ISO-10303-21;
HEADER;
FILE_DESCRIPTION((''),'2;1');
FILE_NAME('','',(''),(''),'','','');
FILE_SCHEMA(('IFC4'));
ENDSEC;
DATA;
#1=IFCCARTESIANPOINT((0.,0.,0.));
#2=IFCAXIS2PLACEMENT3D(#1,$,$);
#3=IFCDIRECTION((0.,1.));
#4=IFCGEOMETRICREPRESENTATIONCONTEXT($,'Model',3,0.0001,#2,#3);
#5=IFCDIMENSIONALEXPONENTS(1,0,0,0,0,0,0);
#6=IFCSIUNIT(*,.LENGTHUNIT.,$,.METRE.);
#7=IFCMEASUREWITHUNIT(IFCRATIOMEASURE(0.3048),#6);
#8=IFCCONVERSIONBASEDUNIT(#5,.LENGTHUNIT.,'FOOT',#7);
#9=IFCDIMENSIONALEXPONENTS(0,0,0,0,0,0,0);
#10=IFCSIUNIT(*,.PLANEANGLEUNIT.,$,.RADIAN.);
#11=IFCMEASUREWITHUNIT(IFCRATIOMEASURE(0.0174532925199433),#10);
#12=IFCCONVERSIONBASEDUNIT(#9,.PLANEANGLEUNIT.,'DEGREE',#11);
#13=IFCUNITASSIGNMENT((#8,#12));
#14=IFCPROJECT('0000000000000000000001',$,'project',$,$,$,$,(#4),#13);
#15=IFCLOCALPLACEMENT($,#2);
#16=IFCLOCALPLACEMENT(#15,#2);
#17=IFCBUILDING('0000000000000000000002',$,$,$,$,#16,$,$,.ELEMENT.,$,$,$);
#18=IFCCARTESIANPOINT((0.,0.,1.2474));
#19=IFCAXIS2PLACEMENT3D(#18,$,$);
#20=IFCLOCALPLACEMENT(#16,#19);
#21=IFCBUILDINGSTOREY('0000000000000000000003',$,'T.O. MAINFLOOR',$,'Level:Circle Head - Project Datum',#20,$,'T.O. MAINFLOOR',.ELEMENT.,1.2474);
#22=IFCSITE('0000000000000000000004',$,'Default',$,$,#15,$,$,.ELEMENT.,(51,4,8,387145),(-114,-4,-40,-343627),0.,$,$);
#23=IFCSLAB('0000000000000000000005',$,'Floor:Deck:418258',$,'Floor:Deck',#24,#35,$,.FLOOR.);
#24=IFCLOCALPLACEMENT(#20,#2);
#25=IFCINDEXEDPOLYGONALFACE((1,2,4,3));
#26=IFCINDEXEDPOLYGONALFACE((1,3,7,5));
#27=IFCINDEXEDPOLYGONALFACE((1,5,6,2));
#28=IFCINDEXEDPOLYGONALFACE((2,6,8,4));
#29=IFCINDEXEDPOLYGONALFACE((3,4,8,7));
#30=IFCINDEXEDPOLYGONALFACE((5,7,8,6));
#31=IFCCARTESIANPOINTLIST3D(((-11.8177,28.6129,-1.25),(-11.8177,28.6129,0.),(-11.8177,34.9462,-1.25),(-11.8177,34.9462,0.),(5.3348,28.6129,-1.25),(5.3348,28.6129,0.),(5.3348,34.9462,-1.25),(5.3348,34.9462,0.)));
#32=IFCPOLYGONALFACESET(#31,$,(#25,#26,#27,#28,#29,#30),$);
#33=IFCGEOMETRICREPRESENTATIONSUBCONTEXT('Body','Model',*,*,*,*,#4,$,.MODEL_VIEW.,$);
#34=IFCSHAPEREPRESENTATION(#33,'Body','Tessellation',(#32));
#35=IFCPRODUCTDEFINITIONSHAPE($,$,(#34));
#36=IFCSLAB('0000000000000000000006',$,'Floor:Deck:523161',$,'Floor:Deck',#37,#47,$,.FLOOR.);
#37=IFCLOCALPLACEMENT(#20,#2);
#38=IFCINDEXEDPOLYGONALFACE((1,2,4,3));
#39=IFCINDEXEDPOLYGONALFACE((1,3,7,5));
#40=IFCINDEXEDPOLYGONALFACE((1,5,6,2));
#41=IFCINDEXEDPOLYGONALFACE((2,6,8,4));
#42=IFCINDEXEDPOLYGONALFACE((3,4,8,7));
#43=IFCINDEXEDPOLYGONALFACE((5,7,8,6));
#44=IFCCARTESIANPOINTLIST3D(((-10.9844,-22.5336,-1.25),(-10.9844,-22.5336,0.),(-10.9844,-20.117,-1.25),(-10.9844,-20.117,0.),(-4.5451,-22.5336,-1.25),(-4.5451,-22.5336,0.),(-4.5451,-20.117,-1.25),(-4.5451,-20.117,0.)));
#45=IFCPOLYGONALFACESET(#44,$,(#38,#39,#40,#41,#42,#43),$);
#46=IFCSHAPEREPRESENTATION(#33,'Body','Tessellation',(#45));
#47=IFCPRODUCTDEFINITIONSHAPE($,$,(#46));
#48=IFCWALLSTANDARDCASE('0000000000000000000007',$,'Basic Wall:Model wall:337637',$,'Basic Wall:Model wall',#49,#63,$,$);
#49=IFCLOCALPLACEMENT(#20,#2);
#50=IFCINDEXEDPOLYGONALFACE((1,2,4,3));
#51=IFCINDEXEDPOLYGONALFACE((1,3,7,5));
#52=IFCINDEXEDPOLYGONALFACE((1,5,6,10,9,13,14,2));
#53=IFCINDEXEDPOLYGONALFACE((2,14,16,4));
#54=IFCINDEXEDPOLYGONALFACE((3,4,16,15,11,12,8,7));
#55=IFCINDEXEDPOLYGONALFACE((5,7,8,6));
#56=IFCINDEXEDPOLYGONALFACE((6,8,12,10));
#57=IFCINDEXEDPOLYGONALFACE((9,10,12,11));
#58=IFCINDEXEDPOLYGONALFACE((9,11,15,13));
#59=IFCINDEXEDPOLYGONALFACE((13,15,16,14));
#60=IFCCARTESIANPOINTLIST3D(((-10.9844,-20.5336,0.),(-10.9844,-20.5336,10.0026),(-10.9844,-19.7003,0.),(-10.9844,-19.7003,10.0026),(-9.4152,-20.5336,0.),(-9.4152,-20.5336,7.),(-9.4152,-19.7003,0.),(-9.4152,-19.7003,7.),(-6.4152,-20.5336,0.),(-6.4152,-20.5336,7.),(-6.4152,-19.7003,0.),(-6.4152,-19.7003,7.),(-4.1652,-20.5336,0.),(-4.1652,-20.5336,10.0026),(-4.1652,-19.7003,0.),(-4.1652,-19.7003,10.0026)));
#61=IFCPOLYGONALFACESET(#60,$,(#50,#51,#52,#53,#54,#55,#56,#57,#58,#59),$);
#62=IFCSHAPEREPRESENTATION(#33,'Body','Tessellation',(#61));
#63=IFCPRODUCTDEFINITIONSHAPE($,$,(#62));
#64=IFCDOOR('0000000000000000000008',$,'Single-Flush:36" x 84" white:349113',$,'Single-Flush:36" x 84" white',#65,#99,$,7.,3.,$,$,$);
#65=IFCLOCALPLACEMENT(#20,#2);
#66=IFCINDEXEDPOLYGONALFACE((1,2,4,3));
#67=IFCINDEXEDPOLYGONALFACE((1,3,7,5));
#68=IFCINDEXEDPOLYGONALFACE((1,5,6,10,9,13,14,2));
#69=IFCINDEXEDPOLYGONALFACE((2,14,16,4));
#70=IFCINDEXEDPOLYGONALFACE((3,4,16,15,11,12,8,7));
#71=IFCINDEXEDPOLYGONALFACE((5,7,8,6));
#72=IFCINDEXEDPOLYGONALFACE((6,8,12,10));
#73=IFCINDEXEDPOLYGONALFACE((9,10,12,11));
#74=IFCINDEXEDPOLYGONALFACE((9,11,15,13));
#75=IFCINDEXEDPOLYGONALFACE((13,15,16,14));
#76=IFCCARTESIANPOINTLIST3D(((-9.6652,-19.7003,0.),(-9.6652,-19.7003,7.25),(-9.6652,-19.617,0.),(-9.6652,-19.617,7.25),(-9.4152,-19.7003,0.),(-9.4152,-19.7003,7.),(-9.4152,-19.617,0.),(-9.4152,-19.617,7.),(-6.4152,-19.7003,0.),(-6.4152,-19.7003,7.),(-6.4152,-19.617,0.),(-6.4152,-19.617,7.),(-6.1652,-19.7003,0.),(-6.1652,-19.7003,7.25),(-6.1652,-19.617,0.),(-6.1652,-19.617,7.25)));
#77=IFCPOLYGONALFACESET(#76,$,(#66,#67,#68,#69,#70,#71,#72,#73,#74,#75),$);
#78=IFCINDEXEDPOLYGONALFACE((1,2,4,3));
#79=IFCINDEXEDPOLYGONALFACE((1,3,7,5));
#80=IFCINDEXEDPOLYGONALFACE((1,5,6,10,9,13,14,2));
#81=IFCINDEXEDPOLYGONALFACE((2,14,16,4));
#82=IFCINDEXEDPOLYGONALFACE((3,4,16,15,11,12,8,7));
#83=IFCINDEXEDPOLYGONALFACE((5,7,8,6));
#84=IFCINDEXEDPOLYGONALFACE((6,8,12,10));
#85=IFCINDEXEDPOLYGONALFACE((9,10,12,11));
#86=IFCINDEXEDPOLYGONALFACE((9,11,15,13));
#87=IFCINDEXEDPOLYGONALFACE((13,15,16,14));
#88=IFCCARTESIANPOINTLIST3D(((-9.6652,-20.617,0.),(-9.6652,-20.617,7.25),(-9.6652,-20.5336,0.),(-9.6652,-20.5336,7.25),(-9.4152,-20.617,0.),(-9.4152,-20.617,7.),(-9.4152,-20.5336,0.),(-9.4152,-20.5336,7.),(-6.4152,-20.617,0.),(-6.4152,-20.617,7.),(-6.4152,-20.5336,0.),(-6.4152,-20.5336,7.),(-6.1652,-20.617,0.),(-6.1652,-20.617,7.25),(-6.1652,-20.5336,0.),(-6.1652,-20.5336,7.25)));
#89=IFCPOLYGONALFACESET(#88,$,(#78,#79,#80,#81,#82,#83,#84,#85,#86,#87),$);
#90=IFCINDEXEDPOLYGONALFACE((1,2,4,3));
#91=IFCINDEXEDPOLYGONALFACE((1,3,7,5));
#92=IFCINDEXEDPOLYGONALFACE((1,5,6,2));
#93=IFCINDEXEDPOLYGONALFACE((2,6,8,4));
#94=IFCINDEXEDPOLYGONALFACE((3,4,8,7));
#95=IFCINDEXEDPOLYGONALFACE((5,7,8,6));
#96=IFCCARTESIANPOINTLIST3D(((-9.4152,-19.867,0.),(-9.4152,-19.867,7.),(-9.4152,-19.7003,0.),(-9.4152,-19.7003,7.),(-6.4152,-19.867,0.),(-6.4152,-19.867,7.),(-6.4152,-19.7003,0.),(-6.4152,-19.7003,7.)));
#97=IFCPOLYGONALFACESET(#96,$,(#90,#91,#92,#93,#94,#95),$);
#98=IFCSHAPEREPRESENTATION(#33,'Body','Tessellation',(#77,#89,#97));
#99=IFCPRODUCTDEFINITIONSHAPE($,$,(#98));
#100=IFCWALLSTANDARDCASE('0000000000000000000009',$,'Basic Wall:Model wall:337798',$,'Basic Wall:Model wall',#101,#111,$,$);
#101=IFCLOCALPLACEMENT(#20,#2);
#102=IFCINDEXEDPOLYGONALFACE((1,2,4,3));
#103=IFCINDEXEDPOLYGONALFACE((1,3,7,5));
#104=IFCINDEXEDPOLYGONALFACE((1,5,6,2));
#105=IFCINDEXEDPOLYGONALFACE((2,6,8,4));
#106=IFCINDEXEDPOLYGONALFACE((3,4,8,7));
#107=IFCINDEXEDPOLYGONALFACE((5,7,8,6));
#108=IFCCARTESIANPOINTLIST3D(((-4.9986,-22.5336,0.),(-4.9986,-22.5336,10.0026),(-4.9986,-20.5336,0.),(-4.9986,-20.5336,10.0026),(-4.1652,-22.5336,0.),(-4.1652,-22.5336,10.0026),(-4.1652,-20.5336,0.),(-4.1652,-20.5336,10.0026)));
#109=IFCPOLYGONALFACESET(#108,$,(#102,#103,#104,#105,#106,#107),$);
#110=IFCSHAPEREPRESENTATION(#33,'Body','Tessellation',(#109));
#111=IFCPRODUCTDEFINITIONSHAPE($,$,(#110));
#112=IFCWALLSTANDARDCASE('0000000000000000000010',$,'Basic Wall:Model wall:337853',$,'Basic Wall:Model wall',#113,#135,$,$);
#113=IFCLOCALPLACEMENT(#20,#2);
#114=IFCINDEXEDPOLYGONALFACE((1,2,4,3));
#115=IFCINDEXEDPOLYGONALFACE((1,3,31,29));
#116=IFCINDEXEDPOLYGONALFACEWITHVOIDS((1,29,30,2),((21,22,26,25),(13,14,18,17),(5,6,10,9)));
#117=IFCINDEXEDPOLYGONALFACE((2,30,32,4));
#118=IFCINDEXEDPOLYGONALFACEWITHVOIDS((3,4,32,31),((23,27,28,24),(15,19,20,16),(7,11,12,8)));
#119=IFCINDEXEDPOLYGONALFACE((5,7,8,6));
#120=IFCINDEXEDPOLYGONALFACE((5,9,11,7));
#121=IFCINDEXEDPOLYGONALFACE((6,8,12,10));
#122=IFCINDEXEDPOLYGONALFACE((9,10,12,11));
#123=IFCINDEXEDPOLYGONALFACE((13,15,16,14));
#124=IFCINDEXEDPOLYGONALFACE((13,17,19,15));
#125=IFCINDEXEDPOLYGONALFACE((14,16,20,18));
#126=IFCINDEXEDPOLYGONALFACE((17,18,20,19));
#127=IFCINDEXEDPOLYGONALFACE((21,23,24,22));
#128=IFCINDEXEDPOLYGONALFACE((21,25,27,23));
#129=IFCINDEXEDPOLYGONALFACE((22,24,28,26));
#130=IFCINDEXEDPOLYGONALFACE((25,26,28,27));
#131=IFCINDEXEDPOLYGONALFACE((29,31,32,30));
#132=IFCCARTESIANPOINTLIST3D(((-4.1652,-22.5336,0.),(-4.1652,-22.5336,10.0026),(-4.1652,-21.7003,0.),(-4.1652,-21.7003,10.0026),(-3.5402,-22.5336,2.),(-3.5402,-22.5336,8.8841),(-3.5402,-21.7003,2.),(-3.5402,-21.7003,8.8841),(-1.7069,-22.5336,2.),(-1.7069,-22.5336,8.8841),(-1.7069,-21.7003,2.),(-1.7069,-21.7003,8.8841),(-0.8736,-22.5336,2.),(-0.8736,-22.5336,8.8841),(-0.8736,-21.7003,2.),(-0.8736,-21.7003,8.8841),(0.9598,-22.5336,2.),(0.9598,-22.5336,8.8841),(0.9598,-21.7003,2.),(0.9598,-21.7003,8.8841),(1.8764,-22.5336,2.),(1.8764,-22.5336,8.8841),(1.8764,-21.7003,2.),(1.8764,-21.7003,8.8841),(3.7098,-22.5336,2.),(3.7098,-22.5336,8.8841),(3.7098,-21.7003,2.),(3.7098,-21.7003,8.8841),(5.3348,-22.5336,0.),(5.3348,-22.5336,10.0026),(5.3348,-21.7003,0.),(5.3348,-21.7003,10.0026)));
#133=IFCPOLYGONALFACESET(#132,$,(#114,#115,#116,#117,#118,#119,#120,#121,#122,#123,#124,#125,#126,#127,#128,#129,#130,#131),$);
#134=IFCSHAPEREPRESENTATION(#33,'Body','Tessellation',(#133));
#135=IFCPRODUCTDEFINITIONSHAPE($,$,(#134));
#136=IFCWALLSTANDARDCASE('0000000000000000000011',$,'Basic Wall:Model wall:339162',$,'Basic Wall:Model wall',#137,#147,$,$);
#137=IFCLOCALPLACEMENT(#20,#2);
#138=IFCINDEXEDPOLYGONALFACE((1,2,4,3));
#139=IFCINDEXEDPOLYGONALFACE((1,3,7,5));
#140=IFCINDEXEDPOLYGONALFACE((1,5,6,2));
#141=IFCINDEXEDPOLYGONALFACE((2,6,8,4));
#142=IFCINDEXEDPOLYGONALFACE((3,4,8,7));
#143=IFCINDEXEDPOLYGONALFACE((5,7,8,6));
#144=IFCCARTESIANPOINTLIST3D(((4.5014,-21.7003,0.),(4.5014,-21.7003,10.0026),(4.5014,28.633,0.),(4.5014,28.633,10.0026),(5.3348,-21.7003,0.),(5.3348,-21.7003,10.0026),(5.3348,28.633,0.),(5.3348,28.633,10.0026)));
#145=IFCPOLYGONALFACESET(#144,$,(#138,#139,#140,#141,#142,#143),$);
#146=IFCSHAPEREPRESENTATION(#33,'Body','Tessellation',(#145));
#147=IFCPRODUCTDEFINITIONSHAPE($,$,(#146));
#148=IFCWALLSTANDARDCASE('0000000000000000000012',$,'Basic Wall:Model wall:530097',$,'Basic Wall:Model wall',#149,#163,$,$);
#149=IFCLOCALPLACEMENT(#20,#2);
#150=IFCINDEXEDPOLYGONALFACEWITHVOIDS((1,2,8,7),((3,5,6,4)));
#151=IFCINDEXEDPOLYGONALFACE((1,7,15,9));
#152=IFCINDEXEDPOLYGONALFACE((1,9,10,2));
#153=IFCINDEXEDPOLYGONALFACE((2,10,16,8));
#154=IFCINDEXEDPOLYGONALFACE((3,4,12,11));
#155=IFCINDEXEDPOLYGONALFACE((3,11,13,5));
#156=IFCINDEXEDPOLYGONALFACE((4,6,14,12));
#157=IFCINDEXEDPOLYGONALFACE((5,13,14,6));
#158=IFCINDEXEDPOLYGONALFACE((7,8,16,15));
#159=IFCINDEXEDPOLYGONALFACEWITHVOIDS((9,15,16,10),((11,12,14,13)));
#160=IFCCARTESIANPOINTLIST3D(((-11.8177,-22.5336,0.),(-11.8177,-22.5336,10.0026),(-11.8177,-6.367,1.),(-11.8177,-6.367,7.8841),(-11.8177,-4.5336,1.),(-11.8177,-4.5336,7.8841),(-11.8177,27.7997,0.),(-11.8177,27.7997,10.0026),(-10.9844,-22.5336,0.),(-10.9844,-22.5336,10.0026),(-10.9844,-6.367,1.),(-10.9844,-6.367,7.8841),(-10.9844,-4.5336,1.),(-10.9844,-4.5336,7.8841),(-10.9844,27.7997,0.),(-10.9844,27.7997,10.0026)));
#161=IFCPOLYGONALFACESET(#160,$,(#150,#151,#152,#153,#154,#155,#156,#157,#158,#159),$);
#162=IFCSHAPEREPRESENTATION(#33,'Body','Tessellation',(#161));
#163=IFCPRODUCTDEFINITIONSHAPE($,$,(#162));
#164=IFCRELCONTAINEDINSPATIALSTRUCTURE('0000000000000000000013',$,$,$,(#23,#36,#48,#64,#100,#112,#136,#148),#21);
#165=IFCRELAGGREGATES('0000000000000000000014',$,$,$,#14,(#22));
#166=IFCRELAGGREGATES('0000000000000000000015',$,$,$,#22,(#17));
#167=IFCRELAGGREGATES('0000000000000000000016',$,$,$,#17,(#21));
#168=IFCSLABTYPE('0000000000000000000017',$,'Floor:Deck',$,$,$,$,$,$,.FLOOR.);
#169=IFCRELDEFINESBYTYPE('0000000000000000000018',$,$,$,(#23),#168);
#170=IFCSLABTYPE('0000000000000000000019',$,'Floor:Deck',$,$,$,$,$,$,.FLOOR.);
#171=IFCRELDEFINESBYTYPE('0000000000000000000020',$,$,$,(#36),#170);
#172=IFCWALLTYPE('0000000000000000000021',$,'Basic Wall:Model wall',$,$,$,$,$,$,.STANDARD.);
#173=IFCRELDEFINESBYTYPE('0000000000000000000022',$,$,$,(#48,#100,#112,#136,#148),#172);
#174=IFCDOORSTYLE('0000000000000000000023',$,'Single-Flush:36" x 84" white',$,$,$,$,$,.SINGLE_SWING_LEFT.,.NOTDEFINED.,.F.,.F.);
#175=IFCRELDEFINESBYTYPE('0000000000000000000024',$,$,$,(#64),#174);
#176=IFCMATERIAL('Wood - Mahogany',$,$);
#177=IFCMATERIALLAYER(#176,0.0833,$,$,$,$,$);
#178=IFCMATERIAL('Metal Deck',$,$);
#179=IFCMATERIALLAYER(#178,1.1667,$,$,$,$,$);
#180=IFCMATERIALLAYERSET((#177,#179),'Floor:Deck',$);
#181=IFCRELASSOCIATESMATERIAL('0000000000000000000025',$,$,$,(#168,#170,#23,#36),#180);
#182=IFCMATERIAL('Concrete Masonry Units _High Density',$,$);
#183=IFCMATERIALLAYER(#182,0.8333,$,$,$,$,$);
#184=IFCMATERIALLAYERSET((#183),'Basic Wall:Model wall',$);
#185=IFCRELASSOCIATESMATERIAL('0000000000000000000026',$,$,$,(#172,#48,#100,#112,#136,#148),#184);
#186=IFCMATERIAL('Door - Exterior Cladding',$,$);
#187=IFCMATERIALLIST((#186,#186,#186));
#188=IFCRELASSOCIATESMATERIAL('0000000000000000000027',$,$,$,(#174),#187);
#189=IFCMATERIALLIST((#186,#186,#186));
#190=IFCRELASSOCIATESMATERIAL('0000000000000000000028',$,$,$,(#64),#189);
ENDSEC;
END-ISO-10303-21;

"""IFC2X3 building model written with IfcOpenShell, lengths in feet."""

from ifc_helpers import new_model, entity, si_unit, converted_unit, direction, frame, frame_2d, origin, origin_2d_with_axis, place, context, subcontext, project, spatial, polyline, rectangle, outline, extrude, source, transform, mapped, material, material_list, layer, layer_set, layer_usage, type_object, type_shapes, element, fill, save


model = new_model("IFC2X3")

# Units and contexts
model_context = context("Model", 3, precision=0.0001, world=origin(), true_north=direction((0.0, 1.0)))
body_context = subcontext(model_context, "Body", "Model", "MODEL_VIEW")
ifc_project = project(units=[converted_unit("LENGTHUNIT", "FOOT", entity("IfcRatioMeasure", 0.3048), si_unit("LENGTHUNIT", "METRE"), dimensions=[1, 0, 0, 0, 0, 0, 0]), converted_unit("PLANEANGLEUNIT", "DEGREE", entity("IfcRatioMeasure", 0.0174532925199433), si_unit("PLANEANGLEUNIT", "RADIAN"), dimensions=[0, 0, 0, 0, 0, 0, 0])], contexts=[model_context])

# Site, building, storey
site_placement = place(None, origin())
site = spatial("IfcSite", under=ifc_project, at=site_placement, Name="Default", CompositionType="ELEMENT", RefLatitude=(51, 4, 8, 387145), RefLongitude=(-114, -4, -40, -343627), RefElevation=0.0)
building_placement = place(site_placement, origin())
building = spatial("IfcBuilding", under=site, at=building_placement, CompositionType="ELEMENT")
storey_placement = place(building_placement, frame((0.0, 0.0, 1.2474)))
storey = spatial("IfcBuildingStorey", under=building, at=storey_placement, Name="T.O. MAINFLOOR", ObjectType="Level:Circle Head - Project Datum", LongName="T.O. MAINFLOOR", CompositionType="ELEMENT", Elevation=1.2474)

# Slabs
ifc_material_1 = material(Name="Wood - Mahogany")
ifc_layer_1 = layer(ifc_material_1, 0.0833)
ifc_material_2 = material(Name="Metal Deck")
ifc_layer_2 = layer(ifc_material_2, 1.1667)
ifc_layer_set_1 = layer_set([ifc_layer_1, ifc_layer_2], Name="Floor:Deck")
ifc_layer_usage_1 = layer_usage(ifc_layer_set_1, "AXIS3", "POSITIVE", 0.0)
slab_type_1 = type_object("IfcSlabType", Name="Floor:Deck", PredefinedType="FLOOR", material=ifc_layer_set_1)
slab_1_placement = place(storey_placement, origin())
element("IfcSlab", 1, at=slab_1_placement, inside=storey, type_object=slab_type_1, material=ifc_layer_usage_1, Name="Floor:Deck:418258", ObjectType="Floor:Deck", PredefinedType="FLOOR", context=body_context, shape_type="SweptSolid", body=[
    extrude(rectangle(XDim=6.3333, YDim=17.1525, at=frame_2d((0.0, 0.0), x_axis=(1.0, 0.0))), frame((-3.2415, 31.7795, 0.0), z_axis=(0.0, 0.0, -1.0), x_axis=(0.0, 1.0, 0.0)), (0.0, 0.0, 1.0), 1.25),
])
ifc_layer_usage_2 = layer_usage(ifc_layer_set_1, "AXIS3", "POSITIVE", 0.0)
slab_type_2 = type_object("IfcSlabType", Name="Floor:Deck", PredefinedType="FLOOR", material=ifc_layer_set_1)
slab_2_placement = place(storey_placement, origin())
element("IfcSlab", 2, at=slab_2_placement, inside=storey, type_object=slab_type_2, material=ifc_layer_usage_2, Name="Floor:Deck:523161", ObjectType="Floor:Deck", PredefinedType="FLOOR", context=body_context, shape_type="SweptSolid", body=[
    extrude(rectangle(XDim=2.4167, YDim=6.4392, at=origin_2d_with_axis()), frame((-7.7648, -21.3253, 0.0), z_axis=(0.0, 0.0, -1.0), x_axis=(0.0, 1.0, 0.0)), (0.0, 0.0, 1.0), 1.25),
])

# Wall, opening, door
ifc_material_3 = material(Name="Concrete Masonry Units _High Density")
ifc_layer_3 = layer(ifc_material_3, 0.8333)
ifc_layer_set_2 = layer_set([ifc_layer_3], Name="Basic Wall:Model wall")
ifc_layer_usage_3 = layer_usage(ifc_layer_set_2, "AXIS2", "NEGATIVE", 0.4167)
wall_type_1 = type_object("IfcWallType", Name="Basic Wall:Model wall", PredefinedType="STANDARD", material=ifc_layer_set_2)
wall_1_placement = place(storey_placement, frame((-10.9844, -20.117, 0.0)))
wall_1 = element("IfcWallStandardCase", 3, at=wall_1_placement, inside=storey, type_object=wall_type_1, material=ifc_layer_usage_3, Name="Basic Wall:Model wall:337637", ObjectType="Basic Wall:Model wall", context=body_context, shape_type="SweptSolid", body=[
    extrude(rectangle(XDim=6.8192, YDim=0.8333, at=frame_2d((3.4096, 0.0), x_axis=(-1.0, 0.0))), origin(), (0.0, 0.0, 1.0), 10.0026),
])
opening_1_placement = place(wall_1_placement, frame((1.5692, -0.4167, 0.0)))
opening_1 = element("IfcOpeningElement", 4, at=opening_1_placement, cuts=wall_1, ObjectType="Opening", context=body_context, shape_type="SweptSolid", body=[
    extrude(rectangle(XDim=3.0, YDim=7.0, at=frame_2d((3.5, 1.5), x_axis=(0.0, -1.0))), frame((0.0, 0.0, 0.0), z_axis=(0.0, 1.0, 0.0), x_axis=(0.0, 0.0, 1.0)), (0.0, 0.0, 1.0), 0.8333),
])
ifc_material_4 = material(Name="Door - Exterior Cladding")
ifc_material_list_1 = material_list([ifc_material_4, ifc_material_4, ifc_material_4])
ifc_material_list_2 = material_list([ifc_material_4, ifc_material_4, ifc_material_4])
door_style_1 = type_object("IfcDoorStyle", Name="Single-Flush:36\" x 84\" white", ConstructionType="NOTDEFINED", OperationType="SINGLE_SWING_LEFT", ParameterTakesPrecedence=False, Sizeable=False, material=ifc_material_list_2)
shared_shape_1 = source(origin(), body_context, "Body", "SweptSolid", [
    extrude(outline(polyline([(-1.75, -3.6875), (1.75, -3.6875), (1.75, 3.5625), (1.5, 3.5625), (1.5, -3.4375), (-1.5, -3.4375), (-1.5, 3.5625), (-1.75, 3.5625), (-1.75, -3.6875)])), frame((1.5, 0.9167, 3.5625), z_axis=(0.0, -1.0, 0.0), x_axis=(-1.0, 0.0, 0.0)), (0.0, 0.0, 1.0), 0.0833),
    extrude(outline(polyline([(-3.6875, -1.75), (3.5625, -1.75), (3.5625, -1.5), (-3.4375, -1.5), (-3.4375, 1.5), (3.5625, 1.5), (3.5625, 1.75), (-3.6875, 1.75), (-3.6875, -1.75)])), frame((1.5, 0.0, 3.5625), z_axis=(0.0, -1.0, 0.0), x_axis=(0.0, 0.0, -1.0)), (0.0, 0.0, 1.0), 0.0833),
    extrude(rectangle(XDim=3.0, YDim=0.1667, at=frame_2d((0.0, 0.0), x_axis=(1.0, 0.0))), frame((1.5, 0.75, 0.0)), (0.0, 0.0, 1.0), 7.0),
])
type_shapes(door_style_1, [shared_shape_1])
door_1_placement = place(opening_1_placement, origin())
door_1 = element("IfcDoor", 5, at=door_1_placement, inside=storey, type_object=door_style_1, material=ifc_material_list_1, Name="Single-Flush:36\" x 84\" white:349113", ObjectType="Single-Flush:36\" x 84\" white", OverallHeight=7.0, OverallWidth=3.0, context=body_context, shape_type="MappedRepresentation", body=[
    mapped(shared_shape_1, transform((0.0, 0.0, 0.0), scale=1.0)),
])
fill(opening_1, door_1)

# Wall
ifc_layer_usage_4 = layer_usage(ifc_layer_set_2, "AXIS2", "NEGATIVE", 0.4167)
wall_2_placement = place(storey_placement, frame((-4.5819, -20.5336, 0.0), z_axis=(0.0, 0.0, 1.0), x_axis=(0.0, -1.0, 0.0)))
element("IfcWallStandardCase", 6, at=wall_2_placement, inside=storey, type_object=wall_type_1, material=ifc_layer_usage_4, Name="Basic Wall:Model wall:337798", ObjectType="Basic Wall:Model wall", context=body_context, shape_type="SweptSolid", body=[
    extrude(rectangle(XDim=2.0, YDim=0.8333, at=frame_2d((1.0, 0.0), x_axis=(-1.0, 0.0))), origin(), (0.0, 0.0, 1.0), 10.0026),
])

# Wall, openings
ifc_layer_usage_5 = layer_usage(ifc_layer_set_2, "AXIS2", "NEGATIVE", 0.4167)
wall_3_placement = place(storey_placement, frame((-4.1652, -22.117, 0.0)))
wall_3 = element("IfcWallStandardCase", 7, at=wall_3_placement, inside=storey, type_object=wall_type_1, material=ifc_layer_usage_5, Name="Basic Wall:Model wall:337853", ObjectType="Basic Wall:Model wall", context=body_context, shape_type="SweptSolid", body=[
    extrude(rectangle(XDim=9.5, YDim=0.8333, at=frame_2d((4.75, 0.0), x_axis=(-1.0, 0.0))), origin(), (0.0, 0.0, 1.0), 10.0026),
])
opening_2_placement = place(wall_3_placement, frame((7.875, 0.4167, 2.0)))
element("IfcOpeningElement", 8, at=opening_2_placement, cuts=wall_3, ObjectType="Opening", context=body_context, shape_type="SweptSolid", body=[
    extrude(rectangle(XDim=6.8841, YDim=1.8333, at=frame_2d((3.4421, 0.9167), x_axis=(-1.0, 0.0))), frame((0.0, 0.0, 0.0), z_axis=(0.0, -1.0, 0.0), x_axis=(0.0, 0.0, 1.0)), (0.0, 0.0, 1.0), 0.8333),
])
opening_3_placement = place(wall_3_placement, frame((5.125, 0.4167, 2.0)))
element("IfcOpeningElement", 9, at=opening_3_placement, cuts=wall_3, ObjectType="Opening", context=body_context, shape_type="SweptSolid", body=[
    extrude(rectangle(XDim=6.8841, YDim=1.8333, at=frame_2d((3.4421, 0.9167), x_axis=(-1.0, 0.0))), frame((0.0, 0.0, 0.0), z_axis=(0.0, -1.0, 0.0), x_axis=(0.0, 0.0, 1.0)), (0.0, 0.0, 1.0), 0.8333),
])
opening_4_placement = place(wall_3_placement, frame((2.4583, 0.4167, 2.0)))
element("IfcOpeningElement", 10, at=opening_4_placement, cuts=wall_3, ObjectType="Opening", context=body_context, shape_type="SweptSolid", body=[
    extrude(rectangle(XDim=6.8841, YDim=1.8333, at=frame_2d((3.4421, 0.9167), x_axis=(-1.0, 0.0))), frame((0.0, 0.0, 0.0), z_axis=(0.0, -1.0, 0.0), x_axis=(0.0, 0.0, 1.0)), (0.0, 0.0, 1.0), 0.8333),
])

# Wall
ifc_layer_usage_6 = layer_usage(ifc_layer_set_2, "AXIS2", "NEGATIVE", 0.4167)
wall_4_placement = place(storey_placement, frame((4.9181, 28.633, 0.0), z_axis=(0.0, 0.0, 1.0), x_axis=(0.0, -1.0, 0.0)))
element("IfcWallStandardCase", 11, at=wall_4_placement, inside=storey, type_object=wall_type_1, material=ifc_layer_usage_6, Name="Basic Wall:Model wall:339162", ObjectType="Basic Wall:Model wall", context=body_context, shape_type="SweptSolid", body=[
    extrude(rectangle(XDim=50.3333, YDim=0.8333, at=frame_2d((25.1667, 0.0), x_axis=(-1.0, 0.0))), origin(), (0.0, 0.0, 1.0), 10.0026),
])

# Wall, opening
ifc_layer_usage_7 = layer_usage(ifc_layer_set_2, "AXIS2", "NEGATIVE", 0.4167)
wall_5_placement = place(storey_placement, frame((-11.401, 27.7997, 0.0), z_axis=(0.0, 0.0, 1.0), x_axis=(0.0, -1.0, 0.0)))
wall_5 = element("IfcWallStandardCase", 12, at=wall_5_placement, inside=storey, type_object=wall_type_1, material=ifc_layer_usage_7, Name="Basic Wall:Model wall:530097", ObjectType="Basic Wall:Model wall", context=body_context, shape_type="SweptSolid", body=[
    extrude(rectangle(XDim=50.3333, YDim=0.8333, at=frame_2d((25.1667, 0.0), x_axis=(-1.0, 0.0))), origin(), (0.0, 0.0, 1.0), 10.0026),
])
opening_5_placement = place(wall_5_placement, frame((34.1667, 0.4167, 1.0)))
element("IfcOpeningElement", 13, at=opening_5_placement, cuts=wall_5, ObjectType="Opening", context=body_context, shape_type="SweptSolid", body=[
    extrude(rectangle(XDim=6.8841, YDim=1.8333, at=frame_2d((3.4421, 0.9167), x_axis=(-1.0, 0.0))), frame((0.0, 0.0, 0.0), z_axis=(0.0, -1.0, 0.0), x_axis=(0.0, 0.0, 1.0)), (0.0, 0.0, 1.0), 0.8333),
])

save(model, "model.ifc")
